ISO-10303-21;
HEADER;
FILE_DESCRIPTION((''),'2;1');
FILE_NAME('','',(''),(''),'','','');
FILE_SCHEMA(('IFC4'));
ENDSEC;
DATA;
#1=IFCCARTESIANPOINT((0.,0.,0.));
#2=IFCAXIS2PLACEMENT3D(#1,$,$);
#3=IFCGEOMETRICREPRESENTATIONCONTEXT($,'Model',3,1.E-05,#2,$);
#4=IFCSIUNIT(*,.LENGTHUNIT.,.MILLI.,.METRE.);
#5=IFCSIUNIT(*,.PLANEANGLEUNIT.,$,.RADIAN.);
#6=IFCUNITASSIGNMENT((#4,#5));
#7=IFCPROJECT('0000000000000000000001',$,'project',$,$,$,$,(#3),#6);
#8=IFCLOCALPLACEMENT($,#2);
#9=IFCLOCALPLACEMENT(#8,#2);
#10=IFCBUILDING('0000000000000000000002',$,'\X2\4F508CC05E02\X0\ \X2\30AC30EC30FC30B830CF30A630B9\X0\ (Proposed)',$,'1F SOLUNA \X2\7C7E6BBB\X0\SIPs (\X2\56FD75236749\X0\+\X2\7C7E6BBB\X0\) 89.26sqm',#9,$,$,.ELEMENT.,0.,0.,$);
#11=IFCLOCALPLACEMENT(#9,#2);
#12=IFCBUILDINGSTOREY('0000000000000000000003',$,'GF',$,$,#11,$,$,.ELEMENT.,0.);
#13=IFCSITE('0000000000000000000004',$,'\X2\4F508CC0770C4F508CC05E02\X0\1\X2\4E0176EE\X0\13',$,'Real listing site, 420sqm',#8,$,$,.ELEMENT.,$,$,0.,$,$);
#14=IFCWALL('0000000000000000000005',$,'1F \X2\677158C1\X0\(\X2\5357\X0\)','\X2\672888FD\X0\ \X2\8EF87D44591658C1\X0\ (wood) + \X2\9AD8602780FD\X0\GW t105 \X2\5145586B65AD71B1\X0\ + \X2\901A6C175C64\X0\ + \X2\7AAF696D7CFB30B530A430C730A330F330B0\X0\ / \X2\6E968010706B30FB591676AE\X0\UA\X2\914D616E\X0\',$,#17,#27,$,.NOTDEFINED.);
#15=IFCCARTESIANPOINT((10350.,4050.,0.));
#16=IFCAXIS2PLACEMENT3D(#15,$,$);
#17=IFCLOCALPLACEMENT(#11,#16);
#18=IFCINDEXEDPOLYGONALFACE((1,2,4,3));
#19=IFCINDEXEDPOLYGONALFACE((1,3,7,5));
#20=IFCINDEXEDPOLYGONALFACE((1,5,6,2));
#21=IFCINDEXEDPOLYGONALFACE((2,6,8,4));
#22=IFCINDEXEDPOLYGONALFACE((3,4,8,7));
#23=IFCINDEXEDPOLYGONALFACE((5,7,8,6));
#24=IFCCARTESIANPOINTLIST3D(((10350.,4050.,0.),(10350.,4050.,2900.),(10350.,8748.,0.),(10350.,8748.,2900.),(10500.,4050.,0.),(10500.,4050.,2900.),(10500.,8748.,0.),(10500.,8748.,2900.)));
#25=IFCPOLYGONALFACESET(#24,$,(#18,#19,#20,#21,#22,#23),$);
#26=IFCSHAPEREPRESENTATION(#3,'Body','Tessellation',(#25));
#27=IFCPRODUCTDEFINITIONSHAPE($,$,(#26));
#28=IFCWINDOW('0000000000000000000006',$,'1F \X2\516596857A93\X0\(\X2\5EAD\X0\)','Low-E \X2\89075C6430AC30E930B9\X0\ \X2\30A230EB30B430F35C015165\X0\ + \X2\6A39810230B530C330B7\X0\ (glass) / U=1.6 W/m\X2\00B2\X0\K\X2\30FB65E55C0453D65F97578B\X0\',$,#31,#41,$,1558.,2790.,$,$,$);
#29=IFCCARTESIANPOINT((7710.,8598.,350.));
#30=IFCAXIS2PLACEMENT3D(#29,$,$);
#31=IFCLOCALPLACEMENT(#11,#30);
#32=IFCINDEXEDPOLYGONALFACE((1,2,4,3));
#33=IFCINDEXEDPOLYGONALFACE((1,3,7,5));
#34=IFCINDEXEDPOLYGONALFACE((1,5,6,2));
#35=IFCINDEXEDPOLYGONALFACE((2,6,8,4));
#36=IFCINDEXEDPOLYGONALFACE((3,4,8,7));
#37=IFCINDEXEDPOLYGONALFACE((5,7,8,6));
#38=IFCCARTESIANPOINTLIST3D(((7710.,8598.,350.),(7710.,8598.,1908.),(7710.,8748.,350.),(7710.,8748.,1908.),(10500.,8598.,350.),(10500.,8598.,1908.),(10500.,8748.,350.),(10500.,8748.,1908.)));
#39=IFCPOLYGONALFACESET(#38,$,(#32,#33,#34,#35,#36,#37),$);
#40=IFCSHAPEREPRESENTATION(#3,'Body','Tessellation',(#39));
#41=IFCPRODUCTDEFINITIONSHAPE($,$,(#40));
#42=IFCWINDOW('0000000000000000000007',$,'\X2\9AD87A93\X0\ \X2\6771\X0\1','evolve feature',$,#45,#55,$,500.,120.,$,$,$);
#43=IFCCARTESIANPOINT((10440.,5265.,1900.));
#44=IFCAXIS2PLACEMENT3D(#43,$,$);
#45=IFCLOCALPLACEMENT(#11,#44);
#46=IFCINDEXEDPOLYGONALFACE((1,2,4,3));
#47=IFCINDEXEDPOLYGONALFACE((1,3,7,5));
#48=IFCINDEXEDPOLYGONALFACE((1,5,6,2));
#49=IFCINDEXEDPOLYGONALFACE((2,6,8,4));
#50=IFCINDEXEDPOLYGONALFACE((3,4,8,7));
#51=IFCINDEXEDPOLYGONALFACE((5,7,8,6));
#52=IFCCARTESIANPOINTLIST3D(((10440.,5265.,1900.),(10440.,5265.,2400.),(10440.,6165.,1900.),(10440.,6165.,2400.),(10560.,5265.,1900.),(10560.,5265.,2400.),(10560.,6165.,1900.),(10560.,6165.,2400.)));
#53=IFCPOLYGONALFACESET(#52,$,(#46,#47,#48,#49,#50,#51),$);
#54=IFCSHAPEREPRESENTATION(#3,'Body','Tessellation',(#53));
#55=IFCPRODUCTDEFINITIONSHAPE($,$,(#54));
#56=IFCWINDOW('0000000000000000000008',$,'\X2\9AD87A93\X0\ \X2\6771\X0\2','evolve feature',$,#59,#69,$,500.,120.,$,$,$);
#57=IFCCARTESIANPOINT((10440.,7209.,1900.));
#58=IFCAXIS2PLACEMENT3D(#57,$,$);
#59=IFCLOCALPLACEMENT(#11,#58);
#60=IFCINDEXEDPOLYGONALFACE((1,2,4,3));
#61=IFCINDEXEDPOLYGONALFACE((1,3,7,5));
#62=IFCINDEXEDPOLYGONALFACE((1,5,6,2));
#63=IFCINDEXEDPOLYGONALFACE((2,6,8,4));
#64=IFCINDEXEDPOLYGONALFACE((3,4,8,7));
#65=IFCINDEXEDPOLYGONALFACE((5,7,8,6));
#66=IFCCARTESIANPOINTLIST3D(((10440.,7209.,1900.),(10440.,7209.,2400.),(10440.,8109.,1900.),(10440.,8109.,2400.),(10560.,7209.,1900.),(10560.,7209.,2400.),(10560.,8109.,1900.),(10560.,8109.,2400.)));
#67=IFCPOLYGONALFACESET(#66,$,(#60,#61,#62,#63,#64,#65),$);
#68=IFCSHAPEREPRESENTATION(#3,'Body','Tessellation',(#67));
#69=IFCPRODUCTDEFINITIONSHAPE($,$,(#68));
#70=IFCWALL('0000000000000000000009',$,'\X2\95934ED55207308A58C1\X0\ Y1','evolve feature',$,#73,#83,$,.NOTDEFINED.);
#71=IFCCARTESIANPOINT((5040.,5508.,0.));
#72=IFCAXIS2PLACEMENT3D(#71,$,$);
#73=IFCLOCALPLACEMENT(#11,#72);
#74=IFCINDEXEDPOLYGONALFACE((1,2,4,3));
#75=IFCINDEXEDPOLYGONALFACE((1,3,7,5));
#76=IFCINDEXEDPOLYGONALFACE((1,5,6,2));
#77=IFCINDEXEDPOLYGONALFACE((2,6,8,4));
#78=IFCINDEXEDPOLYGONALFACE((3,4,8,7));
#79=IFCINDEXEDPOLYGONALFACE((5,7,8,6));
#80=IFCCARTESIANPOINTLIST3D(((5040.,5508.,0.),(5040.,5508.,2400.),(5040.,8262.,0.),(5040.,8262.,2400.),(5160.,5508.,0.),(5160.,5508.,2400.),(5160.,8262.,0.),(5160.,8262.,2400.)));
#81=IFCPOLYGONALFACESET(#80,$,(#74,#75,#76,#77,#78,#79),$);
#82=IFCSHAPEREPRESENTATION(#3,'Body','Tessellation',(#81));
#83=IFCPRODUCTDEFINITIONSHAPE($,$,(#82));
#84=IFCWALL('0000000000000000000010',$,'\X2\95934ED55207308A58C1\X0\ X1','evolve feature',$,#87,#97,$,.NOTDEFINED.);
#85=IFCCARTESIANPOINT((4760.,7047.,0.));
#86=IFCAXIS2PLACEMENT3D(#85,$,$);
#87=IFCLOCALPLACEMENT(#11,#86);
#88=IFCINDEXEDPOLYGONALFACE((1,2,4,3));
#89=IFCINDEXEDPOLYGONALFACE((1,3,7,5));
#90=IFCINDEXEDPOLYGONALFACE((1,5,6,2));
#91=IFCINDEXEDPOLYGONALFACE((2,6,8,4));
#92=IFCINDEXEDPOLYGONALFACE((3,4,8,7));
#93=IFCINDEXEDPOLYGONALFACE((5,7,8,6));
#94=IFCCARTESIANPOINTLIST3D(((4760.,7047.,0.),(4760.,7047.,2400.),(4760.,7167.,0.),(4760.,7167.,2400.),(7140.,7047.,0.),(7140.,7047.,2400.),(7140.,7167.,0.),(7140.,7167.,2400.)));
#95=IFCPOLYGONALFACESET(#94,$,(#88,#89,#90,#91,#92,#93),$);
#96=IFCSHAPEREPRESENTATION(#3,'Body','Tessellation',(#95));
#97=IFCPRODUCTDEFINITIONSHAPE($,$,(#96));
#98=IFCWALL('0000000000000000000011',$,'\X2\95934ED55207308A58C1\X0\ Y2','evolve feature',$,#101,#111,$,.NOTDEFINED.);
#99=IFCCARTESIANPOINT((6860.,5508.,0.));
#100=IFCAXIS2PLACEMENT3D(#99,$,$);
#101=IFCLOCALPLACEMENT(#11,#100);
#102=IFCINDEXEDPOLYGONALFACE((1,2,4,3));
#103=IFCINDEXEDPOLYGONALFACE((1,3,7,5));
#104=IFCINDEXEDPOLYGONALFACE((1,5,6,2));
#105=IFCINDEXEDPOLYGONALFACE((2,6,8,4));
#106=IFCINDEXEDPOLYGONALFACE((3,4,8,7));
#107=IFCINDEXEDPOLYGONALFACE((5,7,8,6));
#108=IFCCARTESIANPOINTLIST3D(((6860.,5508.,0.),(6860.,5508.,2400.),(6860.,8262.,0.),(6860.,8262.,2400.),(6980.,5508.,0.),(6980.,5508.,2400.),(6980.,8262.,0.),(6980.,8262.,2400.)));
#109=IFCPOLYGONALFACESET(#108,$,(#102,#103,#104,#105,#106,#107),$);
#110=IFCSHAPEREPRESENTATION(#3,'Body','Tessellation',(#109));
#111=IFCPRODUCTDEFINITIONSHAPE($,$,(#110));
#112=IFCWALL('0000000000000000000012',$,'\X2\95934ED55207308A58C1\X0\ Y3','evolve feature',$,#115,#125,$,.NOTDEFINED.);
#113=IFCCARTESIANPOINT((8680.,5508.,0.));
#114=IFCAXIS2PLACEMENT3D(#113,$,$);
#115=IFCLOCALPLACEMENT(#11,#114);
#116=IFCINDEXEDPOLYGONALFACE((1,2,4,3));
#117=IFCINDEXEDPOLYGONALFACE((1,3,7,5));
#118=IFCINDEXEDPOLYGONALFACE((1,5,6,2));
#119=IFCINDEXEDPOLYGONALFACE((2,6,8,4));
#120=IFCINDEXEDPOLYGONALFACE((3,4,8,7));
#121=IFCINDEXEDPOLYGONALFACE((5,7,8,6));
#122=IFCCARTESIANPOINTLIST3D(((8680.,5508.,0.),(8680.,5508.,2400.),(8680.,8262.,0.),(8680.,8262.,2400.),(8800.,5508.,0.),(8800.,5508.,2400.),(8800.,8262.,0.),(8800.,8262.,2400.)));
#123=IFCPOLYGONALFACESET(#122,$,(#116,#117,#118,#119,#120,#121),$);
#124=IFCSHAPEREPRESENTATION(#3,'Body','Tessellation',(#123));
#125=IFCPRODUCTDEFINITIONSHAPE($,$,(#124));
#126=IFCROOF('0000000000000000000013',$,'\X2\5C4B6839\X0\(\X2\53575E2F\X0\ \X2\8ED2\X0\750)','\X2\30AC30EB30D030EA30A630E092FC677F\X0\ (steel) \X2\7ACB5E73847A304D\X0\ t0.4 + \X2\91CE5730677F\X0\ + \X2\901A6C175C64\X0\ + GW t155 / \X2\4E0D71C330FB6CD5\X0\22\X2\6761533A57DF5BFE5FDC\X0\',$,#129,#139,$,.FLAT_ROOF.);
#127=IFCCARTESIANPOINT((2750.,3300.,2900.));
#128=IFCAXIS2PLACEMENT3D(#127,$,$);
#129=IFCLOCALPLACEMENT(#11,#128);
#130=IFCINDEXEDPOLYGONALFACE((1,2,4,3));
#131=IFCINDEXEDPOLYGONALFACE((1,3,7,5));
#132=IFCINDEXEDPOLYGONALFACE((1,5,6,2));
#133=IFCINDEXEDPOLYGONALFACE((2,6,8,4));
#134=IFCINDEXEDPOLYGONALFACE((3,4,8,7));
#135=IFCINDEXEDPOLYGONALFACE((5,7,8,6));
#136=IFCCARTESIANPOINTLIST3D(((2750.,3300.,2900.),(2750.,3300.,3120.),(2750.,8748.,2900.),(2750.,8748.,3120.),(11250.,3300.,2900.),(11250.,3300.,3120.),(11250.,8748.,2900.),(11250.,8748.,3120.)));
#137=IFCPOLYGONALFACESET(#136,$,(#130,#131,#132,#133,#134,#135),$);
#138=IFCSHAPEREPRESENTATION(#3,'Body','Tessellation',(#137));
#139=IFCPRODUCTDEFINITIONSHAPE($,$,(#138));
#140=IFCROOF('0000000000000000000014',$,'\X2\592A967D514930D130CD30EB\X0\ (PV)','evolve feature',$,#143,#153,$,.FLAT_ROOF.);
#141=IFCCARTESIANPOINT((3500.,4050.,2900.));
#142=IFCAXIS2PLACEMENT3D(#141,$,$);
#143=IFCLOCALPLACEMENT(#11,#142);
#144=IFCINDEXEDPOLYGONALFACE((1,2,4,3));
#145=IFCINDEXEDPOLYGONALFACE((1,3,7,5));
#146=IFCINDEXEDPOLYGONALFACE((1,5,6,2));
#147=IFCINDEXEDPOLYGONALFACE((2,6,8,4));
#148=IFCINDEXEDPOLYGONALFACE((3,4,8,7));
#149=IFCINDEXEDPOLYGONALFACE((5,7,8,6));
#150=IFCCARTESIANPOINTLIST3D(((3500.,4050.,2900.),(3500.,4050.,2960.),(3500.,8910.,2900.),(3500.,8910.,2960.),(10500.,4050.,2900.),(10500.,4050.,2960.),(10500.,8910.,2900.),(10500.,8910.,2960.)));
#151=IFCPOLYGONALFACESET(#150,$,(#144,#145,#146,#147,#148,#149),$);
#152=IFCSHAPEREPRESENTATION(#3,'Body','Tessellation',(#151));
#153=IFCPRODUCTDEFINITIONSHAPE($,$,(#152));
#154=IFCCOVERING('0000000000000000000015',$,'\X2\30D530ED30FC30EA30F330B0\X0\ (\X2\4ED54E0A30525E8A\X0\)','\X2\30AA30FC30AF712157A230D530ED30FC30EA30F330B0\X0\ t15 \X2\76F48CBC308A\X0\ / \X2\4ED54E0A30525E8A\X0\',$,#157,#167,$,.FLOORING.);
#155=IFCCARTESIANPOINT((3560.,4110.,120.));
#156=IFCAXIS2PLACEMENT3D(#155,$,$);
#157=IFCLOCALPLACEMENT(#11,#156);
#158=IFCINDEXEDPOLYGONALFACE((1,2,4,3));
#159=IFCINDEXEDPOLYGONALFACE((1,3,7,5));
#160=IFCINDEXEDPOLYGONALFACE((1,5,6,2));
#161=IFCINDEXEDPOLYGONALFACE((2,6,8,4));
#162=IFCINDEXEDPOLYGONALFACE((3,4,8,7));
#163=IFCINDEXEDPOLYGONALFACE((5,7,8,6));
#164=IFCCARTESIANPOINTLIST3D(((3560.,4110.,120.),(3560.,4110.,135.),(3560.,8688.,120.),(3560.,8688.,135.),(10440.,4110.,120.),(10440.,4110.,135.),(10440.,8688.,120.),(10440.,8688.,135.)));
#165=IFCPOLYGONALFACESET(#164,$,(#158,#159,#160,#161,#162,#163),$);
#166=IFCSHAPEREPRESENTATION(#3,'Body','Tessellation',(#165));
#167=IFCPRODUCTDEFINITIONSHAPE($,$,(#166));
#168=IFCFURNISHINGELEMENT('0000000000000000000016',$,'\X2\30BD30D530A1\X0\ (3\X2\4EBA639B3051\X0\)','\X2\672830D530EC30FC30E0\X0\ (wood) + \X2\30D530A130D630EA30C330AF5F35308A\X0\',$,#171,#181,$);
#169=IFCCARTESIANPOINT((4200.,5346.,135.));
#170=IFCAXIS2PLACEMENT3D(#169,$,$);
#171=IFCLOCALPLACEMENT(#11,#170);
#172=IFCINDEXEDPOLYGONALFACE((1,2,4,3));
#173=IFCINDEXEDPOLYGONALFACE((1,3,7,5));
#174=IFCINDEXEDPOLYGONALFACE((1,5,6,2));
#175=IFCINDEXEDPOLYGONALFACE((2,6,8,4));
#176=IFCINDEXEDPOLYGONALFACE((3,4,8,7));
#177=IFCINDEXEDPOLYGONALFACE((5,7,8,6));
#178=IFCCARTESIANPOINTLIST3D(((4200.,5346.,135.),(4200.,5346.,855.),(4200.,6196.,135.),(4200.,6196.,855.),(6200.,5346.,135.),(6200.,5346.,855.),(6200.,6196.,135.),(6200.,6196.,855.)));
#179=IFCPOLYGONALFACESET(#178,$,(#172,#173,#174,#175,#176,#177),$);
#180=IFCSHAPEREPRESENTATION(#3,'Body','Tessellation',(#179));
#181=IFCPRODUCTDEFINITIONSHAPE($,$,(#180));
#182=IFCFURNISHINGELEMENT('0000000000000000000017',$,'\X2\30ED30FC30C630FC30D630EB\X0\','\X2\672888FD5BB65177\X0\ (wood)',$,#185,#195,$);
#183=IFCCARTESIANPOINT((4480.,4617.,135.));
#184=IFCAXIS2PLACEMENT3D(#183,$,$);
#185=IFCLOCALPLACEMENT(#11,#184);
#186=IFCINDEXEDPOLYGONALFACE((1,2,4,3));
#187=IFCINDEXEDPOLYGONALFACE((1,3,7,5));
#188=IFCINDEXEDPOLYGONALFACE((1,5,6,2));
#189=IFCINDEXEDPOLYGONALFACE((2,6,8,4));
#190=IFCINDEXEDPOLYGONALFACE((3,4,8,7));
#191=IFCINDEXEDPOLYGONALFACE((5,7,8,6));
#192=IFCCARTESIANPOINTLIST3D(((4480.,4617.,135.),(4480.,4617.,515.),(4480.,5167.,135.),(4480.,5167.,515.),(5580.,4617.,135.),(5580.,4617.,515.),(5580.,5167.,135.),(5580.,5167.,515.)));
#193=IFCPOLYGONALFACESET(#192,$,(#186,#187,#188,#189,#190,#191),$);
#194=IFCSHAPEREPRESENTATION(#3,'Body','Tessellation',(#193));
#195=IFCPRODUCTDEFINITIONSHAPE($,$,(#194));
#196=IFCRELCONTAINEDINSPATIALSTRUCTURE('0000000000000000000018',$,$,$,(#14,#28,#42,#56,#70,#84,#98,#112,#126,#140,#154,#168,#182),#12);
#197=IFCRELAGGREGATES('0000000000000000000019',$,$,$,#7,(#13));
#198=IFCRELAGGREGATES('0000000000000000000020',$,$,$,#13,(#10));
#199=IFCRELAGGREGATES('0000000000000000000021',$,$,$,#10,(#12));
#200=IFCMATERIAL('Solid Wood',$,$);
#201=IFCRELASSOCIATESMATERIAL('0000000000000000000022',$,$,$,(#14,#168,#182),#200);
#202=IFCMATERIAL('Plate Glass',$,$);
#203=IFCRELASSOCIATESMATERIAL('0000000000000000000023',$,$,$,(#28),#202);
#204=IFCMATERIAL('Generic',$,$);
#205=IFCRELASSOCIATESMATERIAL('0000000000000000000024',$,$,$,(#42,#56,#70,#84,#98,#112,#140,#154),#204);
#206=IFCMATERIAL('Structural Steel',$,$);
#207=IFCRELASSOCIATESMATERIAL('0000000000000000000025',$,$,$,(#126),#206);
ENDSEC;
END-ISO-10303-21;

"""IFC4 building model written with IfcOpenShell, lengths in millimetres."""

from ifc_helpers import new_model, si_unit, frame, frame_2d, origin, place, context, project, spatial, rectangle, extrude, material, element, fill, save


model = new_model("IFC4")

# Units and contexts
model_context = context("Model", 3, precision=1e-05, world=origin())
ifc_project = project(units=[si_unit("LENGTHUNIT", "METRE", prefix="MILLI"), si_unit("PLANEANGLEUNIT", "RADIAN")], contexts=[model_context])

# Site, building, storey
site_placement = place(None, origin())
site = spatial("IfcSite", under=ifc_project, at=site_placement, Name="佐賀県佐賀市1丁目13", ObjectType="Real listing site, 420sqm", CompositionType="ELEMENT", RefElevation=0.0)
building_placement = place(site_placement, origin())
building = spatial("IfcBuilding", under=site, at=building_placement, Name="佐賀市 ガレージハウス (Proposed)", ObjectType="1F SOLUNA 籾殻SIPs (国産杉+籾殻) 89.26sqm", CompositionType="ELEMENT", ElevationOfRefHeight=0.0, ElevationOfTerrain=0.0)
storey_placement = place(building_placement, origin())
storey = spatial("IfcBuildingStorey", under=building, at=storey_placement, Name="GF", CompositionType="ELEMENT", Elevation=0.0)

# Shared definitions
ifc_material_1 = material(Name="Solid Wood")
ifc_material_2 = material(Name="Generic")

# Shared definitions
ifc_material_3 = material(Name="Plate Glass")

# Wall, openings, windows
wall_1_placement = place(storey_placement, frame((10350.0, 4050.0, 0.0)))
wall_1 = element("IfcWall", 1, at=wall_1_placement, inside=storey, material=ifc_material_1, Name="1F 東壁(南)", Description="木製 軸組外壁 (wood) + 高性能GW t105 充填断熱 + 通気層 + 窯業系サイディング / 準耐火・外皮UA配慮", PredefinedType="NOTDEFINED", context=model_context, shape_type="SweptSolid", body=[
    extrude(rectangle(XDim=150.0, YDim=4698.0, at=frame_2d((75.0, 2349.0))), frame((10350.0, 4050.0, 0.0)), (0.0, 0.0, 1.0), 2900.0),
])
opening_1_placement = place(storey_placement, frame((7710.0, 8598.0, 350.0)))
opening_1 = element("IfcOpeningElement", 2, at=opening_1_placement, cuts=wall_1, PredefinedType="NOTDEFINED", context=model_context, shape_type="SweptSolid", body=[
    extrude(rectangle(XDim=2790.0, YDim=150.0, at=frame_2d((1395.0, 75.0))), frame((7710.0, 8598.0, 350.0)), (0.0, 0.0, 1.0), 1558.0),
])
opening_2_placement = place(storey_placement, frame((10440.0, 5265.0, 1900.0)))
opening_2 = element("IfcOpeningElement", 3, at=opening_2_placement, cuts=wall_1, PredefinedType="NOTDEFINED", context=model_context, shape_type="SweptSolid", body=[
    extrude(rectangle(XDim=120.0, YDim=900.0, at=frame_2d((60.0, 450.0))), frame((10440.0, 5265.0, 1900.0)), (0.0, 0.0, 1.0), 500.0),
])
opening_3_placement = place(storey_placement, frame((10440.0, 7209.0, 1900.0)))
opening_3 = element("IfcOpeningElement", 4, at=opening_3_placement, cuts=wall_1, PredefinedType="NOTDEFINED", context=model_context, shape_type="SweptSolid", body=[
    extrude(rectangle(XDim=120.0, YDim=900.0, at=frame_2d((60.0, 450.0))), frame((10440.0, 7209.0, 1900.0)), (0.0, 0.0, 1.0), 500.0),
])
window_1_placement = place(storey_placement, frame((7710.0, 8598.0, 350.0)))
window_1 = element("IfcWindow", 5, at=window_1_placement, inside=storey, material=ifc_material_3, Name="1F 入隅窓(庭)", Description="Low-E 複層ガラス アルゴン封入 + 樹脂サッシ (glass) / U=1.6 W/m²K・日射取得型", OverallHeight=1558.0, OverallWidth=2790.0, context=model_context, shape_type="SweptSolid", body=[
    extrude(rectangle(XDim=2790.0, YDim=150.0, at=frame_2d((1395.0, 75.0))), frame((7710.0, 8598.0, 350.0)), (0.0, 0.0, 1.0), 1558.0),
])
fill(opening_1, window_1)
window_2_placement = place(storey_placement, frame((10440.0, 5265.0, 1900.0)))
window_2 = element("IfcWindow", 6, at=window_2_placement, inside=storey, material=ifc_material_2, Name="高窓 東1", Description="evolve feature", OverallHeight=500.0, OverallWidth=120.0, context=model_context, shape_type="SweptSolid", body=[
    extrude(rectangle(XDim=120.0, YDim=900.0, at=frame_2d((60.0, 450.0))), frame((10440.0, 5265.0, 1900.0)), (0.0, 0.0, 1.0), 500.0),
])
fill(opening_2, window_2)
window_3_placement = place(storey_placement, frame((10440.0, 7209.0, 1900.0)))
window_3 = element("IfcWindow", 7, at=window_3_placement, inside=storey, material=ifc_material_2, Name="高窓 東2", Description="evolve feature", OverallHeight=500.0, OverallWidth=120.0, context=model_context, shape_type="SweptSolid", body=[
    extrude(rectangle(XDim=120.0, YDim=900.0, at=frame_2d((60.0, 450.0))), frame((10440.0, 7209.0, 1900.0)), (0.0, 0.0, 1.0), 500.0),
])
fill(opening_3, window_3)

# Walls
wall_2_placement = place(storey_placement, frame((5040.0, 5508.0, 0.0)))
element("IfcWall", 8, at=wall_2_placement, inside=storey, material=ifc_material_2, Name="間仕切り壁 Y1", Description="evolve feature", PredefinedType="NOTDEFINED", context=model_context, shape_type="SweptSolid", body=[
    extrude(rectangle(XDim=120.0, YDim=2754.0, at=frame_2d((60.0, 1377.0))), frame((5040.0, 5508.0, 0.0)), (0.0, 0.0, 1.0), 2400.0),
])
wall_3_placement = place(storey_placement, frame((4760.0, 7047.0, 0.0)))
element("IfcWall", 9, at=wall_3_placement, inside=storey, material=ifc_material_2, Name="間仕切り壁 X1", Description="evolve feature", PredefinedType="NOTDEFINED", context=model_context, shape_type="SweptSolid", body=[
    extrude(rectangle(XDim=2380.0, YDim=120.0, at=frame_2d((1190.0, 60.0))), frame((4760.0, 7047.0, 0.0)), (0.0, 0.0, 1.0), 2400.0),
])
wall_4_placement = place(storey_placement, frame((6860.0, 5508.0, 0.0)))
element("IfcWall", 10, at=wall_4_placement, inside=storey, material=ifc_material_2, Name="間仕切り壁 Y2", Description="evolve feature", PredefinedType="NOTDEFINED", context=model_context, shape_type="SweptSolid", body=[
    extrude(rectangle(XDim=120.0, YDim=2754.0, at=frame_2d((60.0, 1377.0))), frame((6860.0, 5508.0, 0.0)), (0.0, 0.0, 1.0), 2400.0),
])
wall_5_placement = place(storey_placement, frame((8680.0, 5508.0, 0.0)))
element("IfcWall", 11, at=wall_5_placement, inside=storey, material=ifc_material_2, Name="間仕切り壁 Y3", Description="evolve feature", PredefinedType="NOTDEFINED", context=model_context, shape_type="SweptSolid", body=[
    extrude(rectangle(XDim=120.0, YDim=2754.0, at=frame_2d((60.0, 1377.0))), frame((8680.0, 5508.0, 0.0)), (0.0, 0.0, 1.0), 2400.0),
])

# Roofs
ifc_material_4 = material(Name="Structural Steel")
roof_1_placement = place(storey_placement, frame((2750.0, 3300.0, 2900.0)))
element("IfcRoof", 12, at=roof_1_placement, inside=storey, material=ifc_material_4, Name="屋根(南帯 軒750)", Description="ガルバリウム鋼板 (steel) 立平葺き t0.4 + 野地板 + 通気層 + GW t155 / 不燃・法22条区域対応", PredefinedType="FLAT_ROOF", context=model_context, shape_type="SweptSolid", body=[
    extrude(rectangle(XDim=8500.0, YDim=5448.0, at=frame_2d((4250.0, 2724.0))), frame((2750.0, 3300.0, 2900.0)), (0.0, 0.0, 1.0), 220.0),
])
roof_2_placement = place(storey_placement, frame((3500.0, 4050.0, 2900.0)))
element("IfcRoof", 13, at=roof_2_placement, inside=storey, material=ifc_material_2, Name="太陽光パネル (PV)", Description="evolve feature", PredefinedType="FLAT_ROOF", context=model_context, shape_type="SweptSolid", body=[
    extrude(rectangle(XDim=7000.0, YDim=4860.0, at=frame_2d((3500.0, 2430.0))), frame((3500.0, 4050.0, 2900.0)), (0.0, 0.0, 1.0), 60.0),
])

# Covering
covering_placement = place(storey_placement, frame((3560.0, 4110.0, 120.0)))
element("IfcCovering", 14, at=covering_placement, inside=storey, material=ifc_material_2, Name="フローリング (仕上げ床)", Description="オーク無垢フローリング t15 直貼り / 仕上げ床", PredefinedType="FLOORING", context=model_context, shape_type="SweptSolid", body=[
    extrude(rectangle(XDim=6880.0, YDim=4578.0, at=frame_2d((3440.0, 2289.0))), frame((3560.0, 4110.0, 120.0)), (0.0, 0.0, 1.0), 15.0),
])

# Furnishing elements
furnishing_1_placement = place(storey_placement, frame((4200.0, 5346.0, 135.0)))
element("IfcFurnishingElement", 15, at=furnishing_1_placement, inside=storey, material=ifc_material_1, Name="ソファ (3人掛け)", Description="木フレーム (wood) + ファブリック張り", context=model_context, shape_type="SweptSolid", body=[
    extrude(rectangle(XDim=2000.0, YDim=850.0, at=frame_2d((1000.0, 425.0))), frame((4200.0, 5346.0, 135.0)), (0.0, 0.0, 1.0), 720.0),
])
furnishing_2_placement = place(storey_placement, frame((4480.0, 4617.0, 135.0)))
element("IfcFurnishingElement", 16, at=furnishing_2_placement, inside=storey, material=ifc_material_1, Name="ローテーブル", Description="木製家具 (wood)", context=model_context, shape_type="SweptSolid", body=[
    extrude(rectangle(XDim=1100.0, YDim=550.0, at=frame_2d((550.0, 275.0))), frame((4480.0, 4617.0, 135.0)), (0.0, 0.0, 1.0), 380.0),
])

save(model, "model.ifc")
